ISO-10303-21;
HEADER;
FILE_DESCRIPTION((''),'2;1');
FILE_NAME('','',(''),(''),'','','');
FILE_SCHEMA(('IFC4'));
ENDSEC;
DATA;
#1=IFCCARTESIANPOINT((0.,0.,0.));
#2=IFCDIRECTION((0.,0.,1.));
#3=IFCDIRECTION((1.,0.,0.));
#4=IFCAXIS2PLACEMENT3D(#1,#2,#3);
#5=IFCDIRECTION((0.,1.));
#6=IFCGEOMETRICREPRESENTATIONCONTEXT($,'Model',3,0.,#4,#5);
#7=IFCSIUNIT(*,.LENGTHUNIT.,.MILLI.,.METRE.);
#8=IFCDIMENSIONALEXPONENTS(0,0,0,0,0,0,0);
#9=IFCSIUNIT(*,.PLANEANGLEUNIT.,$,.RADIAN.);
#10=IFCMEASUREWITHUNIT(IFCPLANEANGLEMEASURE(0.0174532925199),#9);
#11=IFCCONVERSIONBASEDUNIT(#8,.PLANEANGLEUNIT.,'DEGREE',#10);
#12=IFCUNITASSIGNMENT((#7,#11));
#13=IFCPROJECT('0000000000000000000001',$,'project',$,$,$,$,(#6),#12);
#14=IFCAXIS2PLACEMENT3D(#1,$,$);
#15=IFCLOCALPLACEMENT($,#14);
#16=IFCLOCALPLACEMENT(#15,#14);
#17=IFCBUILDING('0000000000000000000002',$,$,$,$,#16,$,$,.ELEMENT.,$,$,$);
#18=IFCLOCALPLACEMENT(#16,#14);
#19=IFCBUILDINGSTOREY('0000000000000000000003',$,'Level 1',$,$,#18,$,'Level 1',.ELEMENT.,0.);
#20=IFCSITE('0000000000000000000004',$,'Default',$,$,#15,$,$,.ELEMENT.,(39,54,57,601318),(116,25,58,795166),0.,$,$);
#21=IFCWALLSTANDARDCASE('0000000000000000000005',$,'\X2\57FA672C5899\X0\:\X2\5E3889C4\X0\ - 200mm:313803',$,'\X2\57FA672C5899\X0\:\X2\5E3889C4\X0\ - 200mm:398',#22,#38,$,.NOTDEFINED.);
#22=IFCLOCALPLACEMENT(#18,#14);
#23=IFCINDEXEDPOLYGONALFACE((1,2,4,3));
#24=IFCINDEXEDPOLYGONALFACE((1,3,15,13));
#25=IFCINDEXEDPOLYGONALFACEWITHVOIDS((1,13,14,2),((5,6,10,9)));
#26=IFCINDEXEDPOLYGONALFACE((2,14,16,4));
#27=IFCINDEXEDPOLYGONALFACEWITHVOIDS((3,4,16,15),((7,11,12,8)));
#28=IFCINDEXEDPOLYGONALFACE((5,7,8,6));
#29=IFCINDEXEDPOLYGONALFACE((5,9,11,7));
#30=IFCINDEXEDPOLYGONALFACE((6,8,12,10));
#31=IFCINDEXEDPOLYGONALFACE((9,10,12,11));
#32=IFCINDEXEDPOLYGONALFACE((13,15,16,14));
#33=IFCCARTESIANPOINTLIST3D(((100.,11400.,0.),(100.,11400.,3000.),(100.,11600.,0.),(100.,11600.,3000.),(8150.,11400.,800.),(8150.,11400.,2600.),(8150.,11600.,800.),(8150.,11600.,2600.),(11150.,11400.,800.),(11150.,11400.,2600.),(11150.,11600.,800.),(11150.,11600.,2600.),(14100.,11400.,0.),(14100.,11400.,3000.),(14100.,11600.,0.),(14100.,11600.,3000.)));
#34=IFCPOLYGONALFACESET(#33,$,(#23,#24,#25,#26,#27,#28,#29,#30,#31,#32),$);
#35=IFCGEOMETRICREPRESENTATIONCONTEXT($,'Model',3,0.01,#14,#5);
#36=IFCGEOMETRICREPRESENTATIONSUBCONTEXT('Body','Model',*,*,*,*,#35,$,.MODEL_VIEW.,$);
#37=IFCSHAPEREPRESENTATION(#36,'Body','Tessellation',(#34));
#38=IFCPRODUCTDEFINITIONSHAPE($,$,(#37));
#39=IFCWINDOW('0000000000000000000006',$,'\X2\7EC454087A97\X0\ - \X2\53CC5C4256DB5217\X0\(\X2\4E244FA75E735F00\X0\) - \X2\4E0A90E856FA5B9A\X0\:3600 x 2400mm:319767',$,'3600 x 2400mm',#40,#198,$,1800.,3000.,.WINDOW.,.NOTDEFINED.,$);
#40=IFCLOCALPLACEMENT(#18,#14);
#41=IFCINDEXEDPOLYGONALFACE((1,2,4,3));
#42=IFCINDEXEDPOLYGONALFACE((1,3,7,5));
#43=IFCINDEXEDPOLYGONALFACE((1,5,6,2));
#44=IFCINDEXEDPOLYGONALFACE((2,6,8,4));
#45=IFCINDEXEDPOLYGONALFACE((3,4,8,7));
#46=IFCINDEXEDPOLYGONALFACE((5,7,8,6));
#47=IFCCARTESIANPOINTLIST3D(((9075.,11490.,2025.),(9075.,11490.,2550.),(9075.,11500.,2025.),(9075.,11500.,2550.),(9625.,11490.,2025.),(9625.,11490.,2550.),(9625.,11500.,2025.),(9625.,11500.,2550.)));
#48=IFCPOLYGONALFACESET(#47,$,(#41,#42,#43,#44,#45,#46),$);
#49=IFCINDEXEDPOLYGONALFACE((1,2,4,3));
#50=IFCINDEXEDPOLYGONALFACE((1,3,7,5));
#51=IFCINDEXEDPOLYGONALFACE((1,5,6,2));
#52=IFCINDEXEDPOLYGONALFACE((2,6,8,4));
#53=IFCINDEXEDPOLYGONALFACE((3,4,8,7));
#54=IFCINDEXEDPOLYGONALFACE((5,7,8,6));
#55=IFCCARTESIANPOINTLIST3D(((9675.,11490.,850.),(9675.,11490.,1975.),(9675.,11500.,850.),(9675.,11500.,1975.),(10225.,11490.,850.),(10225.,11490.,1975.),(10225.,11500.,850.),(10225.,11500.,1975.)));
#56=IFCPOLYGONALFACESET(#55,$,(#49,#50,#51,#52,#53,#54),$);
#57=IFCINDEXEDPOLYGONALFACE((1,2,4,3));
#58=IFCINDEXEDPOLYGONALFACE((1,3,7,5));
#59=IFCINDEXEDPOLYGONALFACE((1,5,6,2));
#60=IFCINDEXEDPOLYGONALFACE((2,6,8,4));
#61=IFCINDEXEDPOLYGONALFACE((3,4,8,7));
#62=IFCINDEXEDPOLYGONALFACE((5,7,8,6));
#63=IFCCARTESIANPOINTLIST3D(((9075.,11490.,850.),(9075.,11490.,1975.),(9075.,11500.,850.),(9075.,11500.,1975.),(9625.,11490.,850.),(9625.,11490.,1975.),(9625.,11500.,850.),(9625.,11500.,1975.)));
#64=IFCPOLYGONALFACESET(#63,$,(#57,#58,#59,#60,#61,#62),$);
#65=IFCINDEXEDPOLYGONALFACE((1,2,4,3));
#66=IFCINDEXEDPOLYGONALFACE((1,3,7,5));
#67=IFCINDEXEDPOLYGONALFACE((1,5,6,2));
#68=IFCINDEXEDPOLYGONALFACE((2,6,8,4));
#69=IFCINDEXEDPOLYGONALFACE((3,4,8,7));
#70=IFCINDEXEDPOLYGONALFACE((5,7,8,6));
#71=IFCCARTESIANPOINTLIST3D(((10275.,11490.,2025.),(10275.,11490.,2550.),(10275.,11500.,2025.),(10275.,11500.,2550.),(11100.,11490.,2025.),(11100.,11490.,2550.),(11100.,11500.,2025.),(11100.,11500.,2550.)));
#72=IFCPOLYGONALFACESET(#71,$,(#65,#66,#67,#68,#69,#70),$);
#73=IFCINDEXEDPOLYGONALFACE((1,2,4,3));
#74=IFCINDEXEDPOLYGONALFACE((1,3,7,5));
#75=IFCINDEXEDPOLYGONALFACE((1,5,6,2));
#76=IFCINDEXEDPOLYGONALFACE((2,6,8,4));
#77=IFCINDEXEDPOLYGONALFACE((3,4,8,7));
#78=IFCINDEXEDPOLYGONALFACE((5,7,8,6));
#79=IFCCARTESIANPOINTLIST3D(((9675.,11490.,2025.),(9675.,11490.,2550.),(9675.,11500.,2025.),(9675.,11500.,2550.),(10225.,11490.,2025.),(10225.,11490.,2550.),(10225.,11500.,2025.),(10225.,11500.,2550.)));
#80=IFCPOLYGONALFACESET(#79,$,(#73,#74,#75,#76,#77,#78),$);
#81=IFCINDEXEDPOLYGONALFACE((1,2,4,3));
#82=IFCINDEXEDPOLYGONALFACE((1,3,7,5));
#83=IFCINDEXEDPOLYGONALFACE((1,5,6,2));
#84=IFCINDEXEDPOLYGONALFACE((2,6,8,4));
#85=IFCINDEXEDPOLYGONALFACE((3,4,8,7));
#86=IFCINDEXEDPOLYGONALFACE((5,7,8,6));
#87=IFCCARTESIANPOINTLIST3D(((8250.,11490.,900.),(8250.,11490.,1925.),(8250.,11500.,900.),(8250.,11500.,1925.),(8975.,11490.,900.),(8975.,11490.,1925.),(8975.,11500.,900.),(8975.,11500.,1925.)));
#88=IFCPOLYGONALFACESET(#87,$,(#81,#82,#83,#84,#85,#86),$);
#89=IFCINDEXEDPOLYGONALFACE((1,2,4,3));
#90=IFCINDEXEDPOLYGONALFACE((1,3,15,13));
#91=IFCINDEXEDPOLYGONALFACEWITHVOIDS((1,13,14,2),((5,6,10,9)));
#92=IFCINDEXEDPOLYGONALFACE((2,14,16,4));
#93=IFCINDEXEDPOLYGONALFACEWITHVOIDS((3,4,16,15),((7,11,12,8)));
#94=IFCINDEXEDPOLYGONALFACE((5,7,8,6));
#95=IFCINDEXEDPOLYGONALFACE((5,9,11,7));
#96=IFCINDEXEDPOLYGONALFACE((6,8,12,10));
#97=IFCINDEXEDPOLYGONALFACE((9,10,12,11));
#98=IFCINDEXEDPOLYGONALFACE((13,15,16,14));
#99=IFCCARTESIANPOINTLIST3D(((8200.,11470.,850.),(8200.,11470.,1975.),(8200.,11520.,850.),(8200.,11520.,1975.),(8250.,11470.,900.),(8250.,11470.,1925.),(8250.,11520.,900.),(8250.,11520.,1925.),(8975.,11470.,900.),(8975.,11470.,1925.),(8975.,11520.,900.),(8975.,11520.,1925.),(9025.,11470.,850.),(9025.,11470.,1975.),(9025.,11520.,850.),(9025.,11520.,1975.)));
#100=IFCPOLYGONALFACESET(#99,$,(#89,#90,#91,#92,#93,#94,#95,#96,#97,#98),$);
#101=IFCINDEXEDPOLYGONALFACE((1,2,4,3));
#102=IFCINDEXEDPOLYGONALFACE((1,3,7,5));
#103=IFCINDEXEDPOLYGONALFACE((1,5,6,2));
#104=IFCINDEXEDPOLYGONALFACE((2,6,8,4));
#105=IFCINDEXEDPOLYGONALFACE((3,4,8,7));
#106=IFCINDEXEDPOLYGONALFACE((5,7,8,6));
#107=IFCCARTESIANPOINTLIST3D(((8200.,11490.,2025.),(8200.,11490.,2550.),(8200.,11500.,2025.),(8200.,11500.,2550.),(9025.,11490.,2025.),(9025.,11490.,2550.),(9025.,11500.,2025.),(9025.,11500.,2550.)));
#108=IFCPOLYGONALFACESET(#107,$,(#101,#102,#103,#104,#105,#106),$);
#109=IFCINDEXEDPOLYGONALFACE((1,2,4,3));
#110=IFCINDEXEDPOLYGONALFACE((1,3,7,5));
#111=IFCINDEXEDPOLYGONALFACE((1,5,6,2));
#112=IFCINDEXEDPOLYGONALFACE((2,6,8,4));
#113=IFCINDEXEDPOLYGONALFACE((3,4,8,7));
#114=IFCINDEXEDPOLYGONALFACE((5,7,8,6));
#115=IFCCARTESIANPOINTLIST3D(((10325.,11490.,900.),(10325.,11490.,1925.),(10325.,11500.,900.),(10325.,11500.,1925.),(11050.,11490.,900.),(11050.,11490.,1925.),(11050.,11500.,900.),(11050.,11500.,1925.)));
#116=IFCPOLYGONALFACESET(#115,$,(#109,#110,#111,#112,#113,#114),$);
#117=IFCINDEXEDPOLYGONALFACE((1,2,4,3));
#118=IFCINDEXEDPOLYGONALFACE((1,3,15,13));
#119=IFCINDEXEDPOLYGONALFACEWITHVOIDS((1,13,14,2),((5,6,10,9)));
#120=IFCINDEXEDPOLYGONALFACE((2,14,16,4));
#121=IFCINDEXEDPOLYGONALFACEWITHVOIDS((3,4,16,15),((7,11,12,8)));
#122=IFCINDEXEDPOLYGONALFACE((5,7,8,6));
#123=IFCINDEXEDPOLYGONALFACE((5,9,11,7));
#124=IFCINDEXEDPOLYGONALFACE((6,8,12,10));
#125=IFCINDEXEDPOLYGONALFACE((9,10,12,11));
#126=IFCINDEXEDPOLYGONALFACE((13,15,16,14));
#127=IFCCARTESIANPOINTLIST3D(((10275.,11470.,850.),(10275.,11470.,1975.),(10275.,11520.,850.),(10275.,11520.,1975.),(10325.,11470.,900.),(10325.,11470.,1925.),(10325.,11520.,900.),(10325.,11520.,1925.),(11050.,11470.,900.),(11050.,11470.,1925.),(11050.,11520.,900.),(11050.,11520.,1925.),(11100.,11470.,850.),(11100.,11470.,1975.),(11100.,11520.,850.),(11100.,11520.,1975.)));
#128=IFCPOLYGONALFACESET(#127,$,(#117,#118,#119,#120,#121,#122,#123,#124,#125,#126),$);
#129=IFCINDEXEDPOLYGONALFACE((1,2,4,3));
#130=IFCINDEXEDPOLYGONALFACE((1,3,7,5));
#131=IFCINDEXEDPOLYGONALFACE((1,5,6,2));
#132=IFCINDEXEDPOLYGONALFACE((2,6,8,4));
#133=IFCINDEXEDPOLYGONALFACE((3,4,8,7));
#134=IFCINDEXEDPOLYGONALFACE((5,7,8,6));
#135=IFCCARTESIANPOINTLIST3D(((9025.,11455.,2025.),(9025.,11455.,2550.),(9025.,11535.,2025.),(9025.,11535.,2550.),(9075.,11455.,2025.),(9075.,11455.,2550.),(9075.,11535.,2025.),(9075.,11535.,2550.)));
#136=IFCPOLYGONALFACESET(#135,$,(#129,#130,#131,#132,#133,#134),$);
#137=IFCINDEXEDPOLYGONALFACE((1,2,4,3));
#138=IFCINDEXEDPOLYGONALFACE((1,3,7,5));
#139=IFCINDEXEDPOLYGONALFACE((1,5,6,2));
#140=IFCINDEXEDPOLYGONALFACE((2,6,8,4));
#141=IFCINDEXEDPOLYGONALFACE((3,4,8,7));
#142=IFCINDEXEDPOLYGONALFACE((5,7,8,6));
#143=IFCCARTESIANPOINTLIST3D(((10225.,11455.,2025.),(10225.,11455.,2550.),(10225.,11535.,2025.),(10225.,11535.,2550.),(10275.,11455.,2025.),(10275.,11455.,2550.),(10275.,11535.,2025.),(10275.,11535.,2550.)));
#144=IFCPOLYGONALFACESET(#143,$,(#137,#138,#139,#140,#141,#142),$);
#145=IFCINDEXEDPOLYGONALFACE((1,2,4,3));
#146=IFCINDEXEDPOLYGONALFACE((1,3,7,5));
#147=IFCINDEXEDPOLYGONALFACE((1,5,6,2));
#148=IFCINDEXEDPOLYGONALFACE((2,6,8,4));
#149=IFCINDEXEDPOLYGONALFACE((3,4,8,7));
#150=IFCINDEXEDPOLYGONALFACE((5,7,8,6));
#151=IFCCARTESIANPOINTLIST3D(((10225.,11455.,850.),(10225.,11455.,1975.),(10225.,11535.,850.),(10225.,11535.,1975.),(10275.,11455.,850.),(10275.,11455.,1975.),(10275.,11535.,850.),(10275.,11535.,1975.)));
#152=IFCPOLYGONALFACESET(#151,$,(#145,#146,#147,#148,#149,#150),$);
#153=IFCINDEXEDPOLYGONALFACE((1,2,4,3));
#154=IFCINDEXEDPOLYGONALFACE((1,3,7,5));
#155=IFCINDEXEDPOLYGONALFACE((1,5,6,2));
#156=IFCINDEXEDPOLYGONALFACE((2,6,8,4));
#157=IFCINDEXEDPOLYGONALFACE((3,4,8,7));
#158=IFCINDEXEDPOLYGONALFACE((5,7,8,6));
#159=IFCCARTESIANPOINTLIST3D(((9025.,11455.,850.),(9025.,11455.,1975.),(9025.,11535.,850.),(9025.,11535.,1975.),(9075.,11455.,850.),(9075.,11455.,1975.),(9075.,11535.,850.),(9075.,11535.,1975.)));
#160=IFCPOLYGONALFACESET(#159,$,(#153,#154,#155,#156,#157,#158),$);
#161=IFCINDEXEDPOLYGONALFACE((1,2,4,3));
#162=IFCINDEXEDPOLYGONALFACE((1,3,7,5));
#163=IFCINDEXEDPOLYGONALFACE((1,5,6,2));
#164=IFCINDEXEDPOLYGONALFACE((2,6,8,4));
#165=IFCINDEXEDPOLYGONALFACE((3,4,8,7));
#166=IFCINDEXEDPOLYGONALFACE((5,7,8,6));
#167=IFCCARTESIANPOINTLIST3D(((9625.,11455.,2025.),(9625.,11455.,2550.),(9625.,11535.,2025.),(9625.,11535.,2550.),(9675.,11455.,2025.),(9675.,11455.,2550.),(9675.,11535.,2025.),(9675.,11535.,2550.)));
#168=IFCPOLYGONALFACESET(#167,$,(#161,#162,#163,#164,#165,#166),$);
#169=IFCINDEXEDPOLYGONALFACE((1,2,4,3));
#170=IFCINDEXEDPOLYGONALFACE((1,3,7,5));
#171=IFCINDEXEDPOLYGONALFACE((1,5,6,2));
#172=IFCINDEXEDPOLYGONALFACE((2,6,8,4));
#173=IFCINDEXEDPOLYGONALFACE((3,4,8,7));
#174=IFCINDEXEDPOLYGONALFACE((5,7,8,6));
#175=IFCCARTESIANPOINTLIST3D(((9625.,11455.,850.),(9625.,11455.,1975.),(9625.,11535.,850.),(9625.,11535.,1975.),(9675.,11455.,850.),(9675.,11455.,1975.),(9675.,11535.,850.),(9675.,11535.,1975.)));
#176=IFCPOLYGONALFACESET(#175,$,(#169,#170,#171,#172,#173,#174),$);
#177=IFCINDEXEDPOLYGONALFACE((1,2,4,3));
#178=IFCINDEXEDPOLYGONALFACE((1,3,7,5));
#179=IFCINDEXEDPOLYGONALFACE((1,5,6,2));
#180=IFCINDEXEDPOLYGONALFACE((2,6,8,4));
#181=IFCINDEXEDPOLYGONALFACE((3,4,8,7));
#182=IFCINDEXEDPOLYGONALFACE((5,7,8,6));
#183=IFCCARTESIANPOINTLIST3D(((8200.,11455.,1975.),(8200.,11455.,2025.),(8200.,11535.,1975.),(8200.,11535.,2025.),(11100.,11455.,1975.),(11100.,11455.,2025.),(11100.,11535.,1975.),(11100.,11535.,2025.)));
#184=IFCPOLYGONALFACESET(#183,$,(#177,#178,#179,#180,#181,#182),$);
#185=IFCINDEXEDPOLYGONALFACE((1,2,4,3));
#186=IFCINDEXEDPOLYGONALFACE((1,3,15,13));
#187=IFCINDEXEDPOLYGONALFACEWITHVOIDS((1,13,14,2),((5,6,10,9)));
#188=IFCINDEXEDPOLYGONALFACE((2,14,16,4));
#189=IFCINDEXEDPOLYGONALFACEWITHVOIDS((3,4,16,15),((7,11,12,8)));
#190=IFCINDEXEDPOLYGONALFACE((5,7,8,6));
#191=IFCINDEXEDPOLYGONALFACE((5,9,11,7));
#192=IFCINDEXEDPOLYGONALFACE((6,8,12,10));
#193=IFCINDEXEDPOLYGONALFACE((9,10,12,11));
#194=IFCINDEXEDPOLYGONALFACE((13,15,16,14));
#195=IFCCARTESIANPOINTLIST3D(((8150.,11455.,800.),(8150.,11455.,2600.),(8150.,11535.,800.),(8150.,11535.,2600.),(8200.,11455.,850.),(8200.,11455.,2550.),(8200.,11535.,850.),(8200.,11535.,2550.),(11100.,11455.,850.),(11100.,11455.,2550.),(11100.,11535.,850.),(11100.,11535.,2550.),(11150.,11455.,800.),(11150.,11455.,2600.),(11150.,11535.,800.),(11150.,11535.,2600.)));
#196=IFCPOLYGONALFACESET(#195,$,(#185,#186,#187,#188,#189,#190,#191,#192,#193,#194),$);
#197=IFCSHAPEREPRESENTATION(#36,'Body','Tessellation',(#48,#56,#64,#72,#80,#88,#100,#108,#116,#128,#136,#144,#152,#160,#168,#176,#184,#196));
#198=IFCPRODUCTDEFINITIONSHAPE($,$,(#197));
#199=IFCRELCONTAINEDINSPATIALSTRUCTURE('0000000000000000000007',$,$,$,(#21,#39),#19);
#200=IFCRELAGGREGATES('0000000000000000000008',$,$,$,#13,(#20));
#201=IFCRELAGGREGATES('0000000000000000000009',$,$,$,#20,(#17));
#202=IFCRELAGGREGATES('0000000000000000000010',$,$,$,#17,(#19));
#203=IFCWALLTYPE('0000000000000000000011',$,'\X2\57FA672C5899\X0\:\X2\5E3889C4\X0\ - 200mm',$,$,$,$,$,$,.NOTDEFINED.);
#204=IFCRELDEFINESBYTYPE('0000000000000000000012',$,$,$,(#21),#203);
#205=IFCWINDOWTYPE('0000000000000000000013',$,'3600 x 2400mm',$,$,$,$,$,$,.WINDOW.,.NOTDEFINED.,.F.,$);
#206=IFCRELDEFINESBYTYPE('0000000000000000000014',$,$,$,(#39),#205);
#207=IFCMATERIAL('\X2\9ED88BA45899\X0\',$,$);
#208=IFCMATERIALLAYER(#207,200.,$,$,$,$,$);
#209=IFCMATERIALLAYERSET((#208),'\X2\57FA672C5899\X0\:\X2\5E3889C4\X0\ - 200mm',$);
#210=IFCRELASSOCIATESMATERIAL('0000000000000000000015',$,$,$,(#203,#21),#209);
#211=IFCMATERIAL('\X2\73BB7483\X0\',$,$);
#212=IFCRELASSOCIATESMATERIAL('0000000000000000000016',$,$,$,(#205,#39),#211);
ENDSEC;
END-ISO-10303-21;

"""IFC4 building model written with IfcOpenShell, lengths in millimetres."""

from ifc_helpers import new_model, entity, si_unit, converted_unit, direction, frame, frame_2d, origin, origin_with_axes, origin_2d_with_axis, place, context, subcontext, project, spatial, polyline, rectangle, outline, extrude, source, transform, mapped, material, layer, layer_set, layer_usage, type_object, type_shapes, element, fill, save


model = new_model("IFC4")

# Units and contexts
model_context_1 = context("Model", 3, precision=0.0, world=origin_with_axes(), true_north=direction((0.0, 1.0)))
model_context_2 = context("Model", 3, precision=0.01, world=origin(), true_north=direction((0.0, 1.0)))
body_context = subcontext(model_context_2, "Body", "Model", "MODEL_VIEW")
ifc_project = project(units=[si_unit("LENGTHUNIT", "METRE", prefix="MILLI"), converted_unit("PLANEANGLEUNIT", "DEGREE", entity("IfcPlaneAngleMeasure", 0.0174532925199), si_unit("PLANEANGLEUNIT", "RADIAN"), dimensions=[0, 0, 0, 0, 0, 0, 0])], contexts=[model_context_1])

# Site, building, storey
site_placement = place(None, origin())
site = spatial("IfcSite", under=ifc_project, at=site_placement, Name="Default", CompositionType="ELEMENT", RefLatitude=(39, 54, 57, 601318), RefLongitude=(116, 25, 58, 795166), RefElevation=0.0)
building_placement = place(site_placement, origin())
building = spatial("IfcBuilding", under=site, at=building_placement, CompositionType="ELEMENT")
storey_placement = place(building_placement, origin())
storey = spatial("IfcBuildingStorey", under=building, at=storey_placement, Name="Level 1", LongName="Level 1", CompositionType="ELEMENT", Elevation=0.0)

# Shared definitions
ifc_material_1 = material(Name="默认墙")
ifc_layer = layer(ifc_material_1, 200.0)
ifc_layer_set = layer_set([ifc_layer], Name="基本墙:常规 - 200mm")
wall_type = type_object("IfcWallType", Name="基本墙:常规 - 200mm", PredefinedType="NOTDEFINED", material=ifc_layer_set)
ifc_material_2 = material(Name="玻璃")
window_type_1 = type_object("IfcWindowType", Name="3600 x 2400mm", ParameterTakesPrecedence=False, PartitioningType="NOTDEFINED", PredefinedType="WINDOW", material=ifc_material_2)
shared_shape_1 = source(origin(), body_context, "Body", "SweptSolid", [
    extrude(rectangle(XDim=10.0, YDim=550.0, at=origin_2d_with_axis()), frame((1200.0, 95.0, 1225.0), z_axis=(0.0, 0.0, 1.0), x_axis=(0.0, 1.0, 0.0)), (0.0, 0.0, 1.0), 525.0),
    extrude(rectangle(XDim=10.0, YDim=550.0, at=origin_2d_with_axis()), frame((1800.0, 95.0, 50.0), z_axis=(0.0, 0.0, 1.0), x_axis=(0.0, 1.0, 0.0)), (0.0, 0.0, 1.0), 1125.0),
    extrude(rectangle(XDim=10.0, YDim=550.0, at=origin_2d_with_axis()), frame((1200.0, 95.0, 50.0), z_axis=(0.0, 0.0, 1.0), x_axis=(0.0, 1.0, 0.0)), (0.0, 0.0, 1.0), 1125.0),
    extrude(rectangle(XDim=10.0, YDim=825.0, at=origin_2d_with_axis()), frame((2537.5, 95.0, 1225.0), z_axis=(0.0, 0.0, 1.0), x_axis=(0.0, 1.0, 0.0)), (0.0, 0.0, 1.0), 525.0),
    extrude(rectangle(XDim=10.0, YDim=550.0, at=origin_2d_with_axis()), frame((1800.0, 95.0, 1225.0), z_axis=(0.0, 0.0, 1.0), x_axis=(0.0, 1.0, 0.0)), (0.0, 0.0, 1.0), 525.0),
    extrude(rectangle(XDim=10.0, YDim=725.0, at=origin_2d_with_axis()), frame((462.5, 95.0, 100.0), z_axis=(0.0, 0.0, 1.0), x_axis=(0.0, 1.0, 0.0)), (0.0, 0.0, 1.0), 1025.0),
    extrude(outline(polyline([(-562.5, -412.5), (562.5, -412.5), (562.5, 412.5), (-562.5, 412.5), (-562.5, -412.5)]), holes=[polyline([(512.5, -362.5), (-512.5, -362.5), (-512.5, 362.5), (512.5, 362.5), (512.5, -362.5)])]), frame((462.5, 70.0, 612.5), z_axis=(0.0, 1.0, 0.0), x_axis=(0.0, 0.0, -1.0)), (0.0, 0.0, 1.0), 50.0),
    extrude(rectangle(XDim=10.0, YDim=825.0, at=origin_2d_with_axis()), frame((462.5, 95.0, 1225.0), z_axis=(0.0, 0.0, 1.0), x_axis=(0.0, 1.0, 0.0)), (0.0, 0.0, 1.0), 525.0),
    extrude(rectangle(XDim=10.0, YDim=725.0, at=origin_2d_with_axis()), frame((2537.5, 95.0, 100.0), z_axis=(0.0, 0.0, 1.0), x_axis=(0.0, 1.0, 0.0)), (0.0, 0.0, 1.0), 1025.0),
    extrude(outline(polyline([(-562.5, -412.5), (562.5, -412.5), (562.5, 412.5), (-562.5, 412.5), (-562.5, -412.5)]), holes=[polyline([(512.5, -362.5), (-512.5, -362.5), (-512.5, 362.5), (512.5, 362.5), (512.5, -362.5)])]), frame((2537.5, 70.0, 612.5), z_axis=(0.0, 1.0, 0.0), x_axis=(0.0, 0.0, -1.0)), (0.0, 0.0, 1.0), 50.0),
    extrude(rectangle(XDim=80.0, YDim=50.0, at=origin_2d_with_axis()), frame((900.0, 95.0, 1225.0), z_axis=(0.0, 0.0, 1.0), x_axis=(0.0, -1.0, 0.0)), (0.0, 0.0, 1.0), 525.0),
    extrude(rectangle(XDim=80.0, YDim=50.0, at=origin_2d_with_axis()), frame((2100.0, 95.0, 1225.0), z_axis=(0.0, 0.0, 1.0), x_axis=(0.0, -1.0, 0.0)), (0.0, 0.0, 1.0), 525.0),
    extrude(rectangle(XDim=80.0, YDim=50.0, at=origin_2d_with_axis()), frame((2100.0, 95.0, 50.0), z_axis=(0.0, 0.0, 1.0), x_axis=(0.0, -1.0, 0.0)), (0.0, 0.0, 1.0), 1125.0),
    extrude(rectangle(XDim=80.0, YDim=50.0, at=origin_2d_with_axis()), frame((900.0, 95.0, 50.0), z_axis=(0.0, 0.0, 1.0), x_axis=(0.0, -1.0, 0.0)), (0.0, 0.0, 1.0), 1125.0),
    extrude(rectangle(XDim=80.0, YDim=50.0, at=origin_2d_with_axis()), frame((1500.0, 95.0, 1225.0), z_axis=(0.0, 0.0, 1.0), x_axis=(0.0, -1.0, 0.0)), (0.0, 0.0, 1.0), 525.0),
    extrude(rectangle(XDim=80.0, YDim=50.0, at=origin_2d_with_axis()), frame((1500.0, 95.0, 50.0), z_axis=(0.0, 0.0, 1.0), x_axis=(0.0, -1.0, 0.0)), (0.0, 0.0, 1.0), 1125.0),
    extrude(rectangle(XDim=80.0, YDim=2900.0, at=origin_2d_with_axis()), frame((1500.0, 95.0, 1175.0), z_axis=(0.0, 0.0, 1.0), x_axis=(0.0, -1.0, 0.0)), (0.0, 0.0, 1.0), 50.0),
    extrude(outline(polyline([(-1500.0, -900.0), (1500.0, -900.0), (1500.0, 900.0), (-1500.0, 900.0), (-1500.0, -900.0)]), holes=[polyline([(1450.0, -850.0), (-1450.0, -850.0), (-1450.0, 850.0), (1450.0, 850.0), (1450.0, -850.0)])]), frame((1500.0, 55.0, 900.0), z_axis=(0.0, 1.0, 0.0), x_axis=(1.0, 0.0, 0.0)), (0.0, 0.0, 1.0), 80.0),
])
type_shapes(window_type_1, [shared_shape_1])

# Wall, opening, window
ifc_layer_usage_1 = layer_usage(ifc_layer_set, "AXIS2", "NEGATIVE", 100.0)
wall_1_placement = place(storey_placement, frame((100.0, 11500.0, 0.0)))
wall_1 = element("IfcWallStandardCase", 1, at=wall_1_placement, inside=storey, type_object=wall_type, material=ifc_layer_usage_1, Name="基本墙:常规 - 200mm:313803", ObjectType="基本墙:常规 - 200mm:398", PredefinedType="NOTDEFINED", context=body_context, shape_type="SweptSolid", body=[
    extrude(rectangle(XDim=14000.0, YDim=200.0, at=frame_2d((7000.0, 0.0), x_axis=(-1.0, 0.0))), origin(), (0.0, 0.0, 1.0), 3000.0),
])
opening_1_placement = place(wall_1_placement, frame((8050.0, -100.0, 800.0)))
opening_1 = element("IfcOpeningElement", 2, at=opening_1_placement, cuts=wall_1, ObjectType="Opening", PredefinedType="OPENING", context=body_context, shape_type="SweptSolid", body=[
    extrude(rectangle(XDim=1800.0, YDim=3000.0, at=frame_2d((900.0, 1500.0), x_axis=(1.0, 0.0))), frame((0.0, 0.0, 0.0), z_axis=(0.0, 1.0, 0.0), x_axis=(0.0, 0.0, 1.0)), (0.0, 0.0, 1.0), 200.0),
])
window_1_placement = place(opening_1_placement, origin())
window_1 = element("IfcWindow", 3, at=window_1_placement, inside=storey, type_object=window_type_1, material=ifc_material_2, Name="组合窗 - 双层四列(两侧平开) - 上部固定:3600 x 2400mm:319767", ObjectType="3600 x 2400mm", OverallHeight=1800.0, OverallWidth=3000.0, PartitioningType="NOTDEFINED", PredefinedType="WINDOW", context=body_context, shape_type="MappedRepresentation", body=[
    mapped(shared_shape_1, transform((0.0, 0.0, 0.0), scale=1.0)),
])
fill(opening_1, window_1)

save(model, "model.ifc")
